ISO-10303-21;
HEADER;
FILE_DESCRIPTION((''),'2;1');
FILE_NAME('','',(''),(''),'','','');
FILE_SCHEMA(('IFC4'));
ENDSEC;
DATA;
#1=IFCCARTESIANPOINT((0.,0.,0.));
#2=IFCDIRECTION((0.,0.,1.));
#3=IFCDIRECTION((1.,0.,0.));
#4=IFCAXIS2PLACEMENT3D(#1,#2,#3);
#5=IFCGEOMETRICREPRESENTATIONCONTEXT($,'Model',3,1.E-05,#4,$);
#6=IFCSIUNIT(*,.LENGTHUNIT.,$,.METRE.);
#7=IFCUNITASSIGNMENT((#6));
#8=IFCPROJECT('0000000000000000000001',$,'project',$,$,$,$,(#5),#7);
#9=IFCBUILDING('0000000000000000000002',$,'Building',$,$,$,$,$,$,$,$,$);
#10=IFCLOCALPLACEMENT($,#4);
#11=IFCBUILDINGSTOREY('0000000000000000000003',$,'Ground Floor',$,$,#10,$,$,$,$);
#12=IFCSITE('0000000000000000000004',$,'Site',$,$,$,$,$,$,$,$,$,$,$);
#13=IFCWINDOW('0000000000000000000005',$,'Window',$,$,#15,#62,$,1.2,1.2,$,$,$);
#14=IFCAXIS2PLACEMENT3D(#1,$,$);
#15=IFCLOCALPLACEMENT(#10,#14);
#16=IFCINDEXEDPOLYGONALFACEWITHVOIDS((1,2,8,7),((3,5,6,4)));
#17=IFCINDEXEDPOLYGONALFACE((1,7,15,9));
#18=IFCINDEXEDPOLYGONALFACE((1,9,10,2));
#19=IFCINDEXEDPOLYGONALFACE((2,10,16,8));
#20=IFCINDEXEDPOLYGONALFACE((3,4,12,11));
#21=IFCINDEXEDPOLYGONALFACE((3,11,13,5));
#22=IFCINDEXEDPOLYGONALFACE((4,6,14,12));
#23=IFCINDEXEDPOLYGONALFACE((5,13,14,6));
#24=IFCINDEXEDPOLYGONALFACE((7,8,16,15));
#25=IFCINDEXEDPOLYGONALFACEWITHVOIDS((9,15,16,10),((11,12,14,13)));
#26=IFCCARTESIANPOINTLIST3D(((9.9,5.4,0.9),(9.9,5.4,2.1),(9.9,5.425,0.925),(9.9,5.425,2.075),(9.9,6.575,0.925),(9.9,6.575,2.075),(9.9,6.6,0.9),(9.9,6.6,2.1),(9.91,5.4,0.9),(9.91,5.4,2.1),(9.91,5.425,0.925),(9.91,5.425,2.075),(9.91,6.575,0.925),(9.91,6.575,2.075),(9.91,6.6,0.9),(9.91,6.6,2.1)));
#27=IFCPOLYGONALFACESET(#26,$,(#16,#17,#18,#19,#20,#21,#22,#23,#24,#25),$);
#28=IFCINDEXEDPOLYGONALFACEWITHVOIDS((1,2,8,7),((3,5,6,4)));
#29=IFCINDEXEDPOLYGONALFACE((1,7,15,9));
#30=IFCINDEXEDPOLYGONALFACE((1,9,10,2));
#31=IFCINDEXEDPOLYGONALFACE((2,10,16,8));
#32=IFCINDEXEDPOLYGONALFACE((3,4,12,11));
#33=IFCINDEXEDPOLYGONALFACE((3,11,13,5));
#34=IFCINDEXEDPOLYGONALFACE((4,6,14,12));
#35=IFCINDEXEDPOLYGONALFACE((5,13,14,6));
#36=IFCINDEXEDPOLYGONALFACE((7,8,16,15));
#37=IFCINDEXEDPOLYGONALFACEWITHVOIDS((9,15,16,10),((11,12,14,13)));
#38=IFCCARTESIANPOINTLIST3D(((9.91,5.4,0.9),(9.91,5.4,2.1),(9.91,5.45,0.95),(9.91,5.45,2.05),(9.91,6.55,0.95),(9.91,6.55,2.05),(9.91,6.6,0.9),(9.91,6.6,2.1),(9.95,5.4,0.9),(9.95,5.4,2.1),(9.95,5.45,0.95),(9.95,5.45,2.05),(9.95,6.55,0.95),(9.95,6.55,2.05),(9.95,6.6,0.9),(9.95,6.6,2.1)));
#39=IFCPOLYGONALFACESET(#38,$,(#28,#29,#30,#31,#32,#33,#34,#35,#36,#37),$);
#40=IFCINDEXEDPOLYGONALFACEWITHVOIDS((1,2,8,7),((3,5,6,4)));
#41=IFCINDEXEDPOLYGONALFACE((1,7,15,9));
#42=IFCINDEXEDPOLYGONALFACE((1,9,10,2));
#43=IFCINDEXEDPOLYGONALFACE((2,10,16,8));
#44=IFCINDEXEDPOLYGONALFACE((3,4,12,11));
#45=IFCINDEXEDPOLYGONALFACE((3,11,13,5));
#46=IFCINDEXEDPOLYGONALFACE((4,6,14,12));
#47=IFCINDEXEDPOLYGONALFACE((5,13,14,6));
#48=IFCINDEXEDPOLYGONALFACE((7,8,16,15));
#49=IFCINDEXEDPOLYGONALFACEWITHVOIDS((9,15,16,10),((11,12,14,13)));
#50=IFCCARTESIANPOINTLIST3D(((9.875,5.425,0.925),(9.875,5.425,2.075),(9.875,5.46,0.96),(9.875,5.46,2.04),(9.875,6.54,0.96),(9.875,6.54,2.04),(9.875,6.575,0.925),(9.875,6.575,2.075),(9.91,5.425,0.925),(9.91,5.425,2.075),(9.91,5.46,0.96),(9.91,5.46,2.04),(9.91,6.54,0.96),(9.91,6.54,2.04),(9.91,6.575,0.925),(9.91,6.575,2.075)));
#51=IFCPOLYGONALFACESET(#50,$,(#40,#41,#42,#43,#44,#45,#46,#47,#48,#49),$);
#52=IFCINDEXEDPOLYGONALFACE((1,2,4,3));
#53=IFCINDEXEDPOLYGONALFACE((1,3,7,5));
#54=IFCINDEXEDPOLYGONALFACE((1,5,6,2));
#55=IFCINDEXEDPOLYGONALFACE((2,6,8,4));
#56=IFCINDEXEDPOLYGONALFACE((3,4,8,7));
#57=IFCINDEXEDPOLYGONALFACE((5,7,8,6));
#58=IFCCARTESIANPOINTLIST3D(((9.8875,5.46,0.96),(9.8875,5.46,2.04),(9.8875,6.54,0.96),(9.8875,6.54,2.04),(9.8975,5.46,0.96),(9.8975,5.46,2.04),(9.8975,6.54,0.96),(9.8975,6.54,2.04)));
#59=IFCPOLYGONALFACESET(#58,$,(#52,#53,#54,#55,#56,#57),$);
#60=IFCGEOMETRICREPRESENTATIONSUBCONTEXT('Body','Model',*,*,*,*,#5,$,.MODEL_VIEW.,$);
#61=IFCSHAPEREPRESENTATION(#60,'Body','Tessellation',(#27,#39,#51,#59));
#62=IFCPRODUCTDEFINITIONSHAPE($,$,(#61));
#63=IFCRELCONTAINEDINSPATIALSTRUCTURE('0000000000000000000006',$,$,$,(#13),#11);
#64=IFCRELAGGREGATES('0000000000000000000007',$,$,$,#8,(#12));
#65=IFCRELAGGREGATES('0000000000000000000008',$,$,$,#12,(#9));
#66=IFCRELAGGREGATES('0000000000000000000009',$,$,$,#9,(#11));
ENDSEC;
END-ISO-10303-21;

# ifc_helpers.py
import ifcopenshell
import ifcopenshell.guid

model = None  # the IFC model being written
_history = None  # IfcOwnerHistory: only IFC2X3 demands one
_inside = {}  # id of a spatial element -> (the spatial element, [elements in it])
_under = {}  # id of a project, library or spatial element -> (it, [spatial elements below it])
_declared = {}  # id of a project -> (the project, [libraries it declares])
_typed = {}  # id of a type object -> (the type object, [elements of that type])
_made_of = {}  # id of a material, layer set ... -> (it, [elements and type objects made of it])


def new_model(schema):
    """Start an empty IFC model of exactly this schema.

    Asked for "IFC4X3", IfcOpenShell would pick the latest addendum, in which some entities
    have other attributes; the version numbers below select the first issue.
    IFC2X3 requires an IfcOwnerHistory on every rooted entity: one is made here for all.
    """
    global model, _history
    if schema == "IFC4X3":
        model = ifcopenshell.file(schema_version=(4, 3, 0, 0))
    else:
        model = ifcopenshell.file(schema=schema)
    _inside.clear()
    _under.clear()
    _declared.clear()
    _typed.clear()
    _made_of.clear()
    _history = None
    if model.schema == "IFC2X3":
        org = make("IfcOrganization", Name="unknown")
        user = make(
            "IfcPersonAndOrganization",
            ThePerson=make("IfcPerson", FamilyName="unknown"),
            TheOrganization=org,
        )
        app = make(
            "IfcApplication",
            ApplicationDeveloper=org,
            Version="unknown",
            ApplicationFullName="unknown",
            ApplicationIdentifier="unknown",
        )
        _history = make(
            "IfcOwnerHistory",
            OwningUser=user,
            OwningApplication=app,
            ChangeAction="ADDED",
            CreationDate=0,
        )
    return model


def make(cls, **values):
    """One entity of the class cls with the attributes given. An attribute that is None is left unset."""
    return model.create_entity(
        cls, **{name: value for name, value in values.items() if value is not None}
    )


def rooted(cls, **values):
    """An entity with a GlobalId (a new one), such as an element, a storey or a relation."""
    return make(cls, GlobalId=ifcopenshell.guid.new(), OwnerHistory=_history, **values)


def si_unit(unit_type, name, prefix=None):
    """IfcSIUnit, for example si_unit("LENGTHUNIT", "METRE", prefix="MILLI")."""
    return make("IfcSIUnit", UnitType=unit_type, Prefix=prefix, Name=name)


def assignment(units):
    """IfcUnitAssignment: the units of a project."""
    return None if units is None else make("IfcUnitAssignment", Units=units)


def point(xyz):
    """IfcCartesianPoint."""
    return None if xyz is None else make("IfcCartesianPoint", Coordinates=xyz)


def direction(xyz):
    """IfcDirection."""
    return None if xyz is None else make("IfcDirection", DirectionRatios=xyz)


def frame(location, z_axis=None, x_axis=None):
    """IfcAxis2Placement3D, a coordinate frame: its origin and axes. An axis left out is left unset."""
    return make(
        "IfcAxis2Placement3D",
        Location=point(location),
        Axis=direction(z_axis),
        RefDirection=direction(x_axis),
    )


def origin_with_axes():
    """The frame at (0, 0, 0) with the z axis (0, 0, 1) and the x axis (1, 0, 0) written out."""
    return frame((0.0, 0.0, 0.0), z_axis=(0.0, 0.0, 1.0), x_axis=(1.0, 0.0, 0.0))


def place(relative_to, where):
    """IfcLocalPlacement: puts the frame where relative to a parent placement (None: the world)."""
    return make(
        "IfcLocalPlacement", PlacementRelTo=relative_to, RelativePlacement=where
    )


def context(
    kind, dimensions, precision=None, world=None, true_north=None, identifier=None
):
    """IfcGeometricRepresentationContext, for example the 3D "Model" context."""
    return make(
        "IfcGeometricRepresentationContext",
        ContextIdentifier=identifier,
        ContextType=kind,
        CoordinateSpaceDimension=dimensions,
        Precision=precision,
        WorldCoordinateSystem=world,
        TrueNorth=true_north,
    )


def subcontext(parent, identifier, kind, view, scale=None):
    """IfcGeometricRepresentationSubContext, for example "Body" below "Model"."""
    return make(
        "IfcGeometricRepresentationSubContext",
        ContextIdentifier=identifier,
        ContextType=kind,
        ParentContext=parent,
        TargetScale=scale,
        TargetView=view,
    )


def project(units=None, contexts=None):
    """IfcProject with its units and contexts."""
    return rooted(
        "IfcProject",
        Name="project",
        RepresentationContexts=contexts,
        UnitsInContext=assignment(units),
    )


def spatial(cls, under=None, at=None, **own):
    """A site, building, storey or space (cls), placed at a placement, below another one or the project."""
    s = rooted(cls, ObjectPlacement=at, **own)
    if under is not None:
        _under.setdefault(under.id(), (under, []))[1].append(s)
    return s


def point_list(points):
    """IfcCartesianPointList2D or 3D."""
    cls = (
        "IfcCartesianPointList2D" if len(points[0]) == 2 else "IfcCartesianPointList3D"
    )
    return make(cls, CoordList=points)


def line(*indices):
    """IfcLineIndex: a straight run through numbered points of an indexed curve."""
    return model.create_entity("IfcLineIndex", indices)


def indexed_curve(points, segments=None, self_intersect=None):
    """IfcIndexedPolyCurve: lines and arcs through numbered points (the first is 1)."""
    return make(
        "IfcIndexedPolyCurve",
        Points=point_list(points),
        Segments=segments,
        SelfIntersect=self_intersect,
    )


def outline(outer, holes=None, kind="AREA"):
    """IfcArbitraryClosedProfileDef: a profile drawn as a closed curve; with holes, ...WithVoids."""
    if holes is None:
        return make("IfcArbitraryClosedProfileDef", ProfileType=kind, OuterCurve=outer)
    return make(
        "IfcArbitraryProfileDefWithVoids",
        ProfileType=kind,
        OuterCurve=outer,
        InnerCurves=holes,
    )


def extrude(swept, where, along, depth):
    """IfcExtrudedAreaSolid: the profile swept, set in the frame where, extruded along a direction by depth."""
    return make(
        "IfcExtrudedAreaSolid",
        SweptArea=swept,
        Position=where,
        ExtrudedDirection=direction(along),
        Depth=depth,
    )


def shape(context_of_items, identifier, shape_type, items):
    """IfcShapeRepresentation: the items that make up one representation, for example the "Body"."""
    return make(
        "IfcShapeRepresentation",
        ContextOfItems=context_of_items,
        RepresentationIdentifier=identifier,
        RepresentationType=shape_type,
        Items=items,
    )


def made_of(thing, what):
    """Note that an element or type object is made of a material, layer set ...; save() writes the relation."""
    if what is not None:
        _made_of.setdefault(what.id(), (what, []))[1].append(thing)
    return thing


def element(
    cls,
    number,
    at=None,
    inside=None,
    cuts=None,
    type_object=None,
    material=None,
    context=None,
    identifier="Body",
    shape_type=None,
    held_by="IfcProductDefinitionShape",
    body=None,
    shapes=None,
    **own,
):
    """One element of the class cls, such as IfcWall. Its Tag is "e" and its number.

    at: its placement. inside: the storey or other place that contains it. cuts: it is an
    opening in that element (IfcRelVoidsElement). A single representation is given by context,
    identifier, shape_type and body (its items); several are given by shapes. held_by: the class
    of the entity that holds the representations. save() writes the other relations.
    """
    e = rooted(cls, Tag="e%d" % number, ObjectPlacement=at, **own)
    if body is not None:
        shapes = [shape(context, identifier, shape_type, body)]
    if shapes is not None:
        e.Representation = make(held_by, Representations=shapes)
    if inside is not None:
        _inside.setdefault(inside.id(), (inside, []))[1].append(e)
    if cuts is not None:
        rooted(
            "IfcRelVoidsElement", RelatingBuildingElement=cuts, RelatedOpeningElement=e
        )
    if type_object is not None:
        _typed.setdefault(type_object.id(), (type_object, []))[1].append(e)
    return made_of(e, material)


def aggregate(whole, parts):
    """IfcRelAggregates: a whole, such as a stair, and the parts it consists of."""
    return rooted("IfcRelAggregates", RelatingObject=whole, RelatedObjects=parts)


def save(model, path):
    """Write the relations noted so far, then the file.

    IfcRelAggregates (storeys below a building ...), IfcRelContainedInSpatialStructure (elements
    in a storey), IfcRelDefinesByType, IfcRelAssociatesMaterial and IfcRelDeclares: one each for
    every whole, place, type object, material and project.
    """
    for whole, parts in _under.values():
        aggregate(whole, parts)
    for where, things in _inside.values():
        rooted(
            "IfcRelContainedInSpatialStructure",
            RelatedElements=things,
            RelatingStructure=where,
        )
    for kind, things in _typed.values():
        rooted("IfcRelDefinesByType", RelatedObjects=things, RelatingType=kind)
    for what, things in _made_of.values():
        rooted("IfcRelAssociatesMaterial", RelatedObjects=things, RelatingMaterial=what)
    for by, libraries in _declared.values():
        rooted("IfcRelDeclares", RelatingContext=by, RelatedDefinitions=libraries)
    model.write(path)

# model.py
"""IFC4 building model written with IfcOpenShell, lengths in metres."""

from ifc_helpers import new_model, si_unit, frame, origin_with_axes, place, context, subcontext, project, spatial, line, indexed_curve, outline, extrude, element, save


model = new_model("IFC4")

# Units and contexts
model_context = context("Model", 3, precision=1e-05, world=origin_with_axes())
body_context = subcontext(model_context, "Body", "Model", "MODEL_VIEW")
ifc_project = project(units=[si_unit("LENGTHUNIT", "METRE")], contexts=[model_context])

# Site, building, storey
site = spatial("IfcSite", under=ifc_project, Name="Site")
building = spatial("IfcBuilding", under=site, Name="Building")
storey_placement = place(None, origin_with_axes())
storey = spatial("IfcBuildingStorey", under=building, at=storey_placement, Name="Ground Floor")

# Window
window_1_placement = place(storey_placement, frame((10.0, 5.4, 0.9), z_axis=(0.0, 0.0, 1.0), x_axis=(0.0, 1.0, 0.0)))
element("IfcWindow", 1, at=window_1_placement, inside=storey, Name="Window", OverallHeight=1.2, OverallWidth=1.2, context=body_context, shape_type="SweptSolid", body=[
    extrude(outline(indexed_curve([(0.0, 0.0), (1.2, 0.0), (1.2, 1.2), (0.0, 1.2)], segments=[line(1, 2, 3, 4, 1)]), holes=[indexed_curve([(0.025, 0.025), (1.175, 0.025), (1.175, 1.175), (0.025, 1.175)], segments=[line(1, 2, 3, 4, 1)])]), frame((0.0, 0.09, 0.0), z_axis=(0.0, -1.0, 0.0), x_axis=(1.0, 0.0, 0.0)), (0.0, 0.0, -1.0), 0.01),
    extrude(outline(indexed_curve([(0.0, 0.0), (1.2, 0.0), (1.2, 1.2), (0.0, 1.2)], segments=[line(1, 2, 3, 4, 1)]), holes=[indexed_curve([(0.05, 0.05), (1.15, 0.05), (1.15, 1.15), (0.05, 1.15)], segments=[line(1, 2, 3, 4, 1)])]), frame((0.0, 0.05, 0.0), z_axis=(0.0, -1.0, 0.0), x_axis=(1.0, 0.0, 0.0)), (0.0, 0.0, -1.0), 0.04),
    extrude(outline(indexed_curve([(0.0, 0.0), (1.15, 0.0), (1.15, 1.15), (0.0, 1.15)], segments=[line(1, 2, 3, 4, 1)]), holes=[indexed_curve([(0.035, 0.035), (1.115, 0.035), (1.115, 1.115), (0.035, 1.115)], segments=[line(1, 2, 3, 4, 1)])]), frame((0.025, 0.09, 0.025), z_axis=(0.0, -1.0, 0.0), x_axis=(1.0, 0.0, 0.0)), (0.0, 0.0, -1.0), 0.035),
    extrude(outline(indexed_curve([(0.035, 0.035), (1.115, 0.035), (1.115, 1.115), (0.035, 1.115)], segments=[line(1, 2, 3, 4, 1)])), frame((0.025, 0.1025, 0.025), z_axis=(0.0, -1.0, 0.0), x_axis=(1.0, 0.0, 0.0)), (0.0, 0.0, -1.0), 0.01),
])

save(model, "model.ifc")
